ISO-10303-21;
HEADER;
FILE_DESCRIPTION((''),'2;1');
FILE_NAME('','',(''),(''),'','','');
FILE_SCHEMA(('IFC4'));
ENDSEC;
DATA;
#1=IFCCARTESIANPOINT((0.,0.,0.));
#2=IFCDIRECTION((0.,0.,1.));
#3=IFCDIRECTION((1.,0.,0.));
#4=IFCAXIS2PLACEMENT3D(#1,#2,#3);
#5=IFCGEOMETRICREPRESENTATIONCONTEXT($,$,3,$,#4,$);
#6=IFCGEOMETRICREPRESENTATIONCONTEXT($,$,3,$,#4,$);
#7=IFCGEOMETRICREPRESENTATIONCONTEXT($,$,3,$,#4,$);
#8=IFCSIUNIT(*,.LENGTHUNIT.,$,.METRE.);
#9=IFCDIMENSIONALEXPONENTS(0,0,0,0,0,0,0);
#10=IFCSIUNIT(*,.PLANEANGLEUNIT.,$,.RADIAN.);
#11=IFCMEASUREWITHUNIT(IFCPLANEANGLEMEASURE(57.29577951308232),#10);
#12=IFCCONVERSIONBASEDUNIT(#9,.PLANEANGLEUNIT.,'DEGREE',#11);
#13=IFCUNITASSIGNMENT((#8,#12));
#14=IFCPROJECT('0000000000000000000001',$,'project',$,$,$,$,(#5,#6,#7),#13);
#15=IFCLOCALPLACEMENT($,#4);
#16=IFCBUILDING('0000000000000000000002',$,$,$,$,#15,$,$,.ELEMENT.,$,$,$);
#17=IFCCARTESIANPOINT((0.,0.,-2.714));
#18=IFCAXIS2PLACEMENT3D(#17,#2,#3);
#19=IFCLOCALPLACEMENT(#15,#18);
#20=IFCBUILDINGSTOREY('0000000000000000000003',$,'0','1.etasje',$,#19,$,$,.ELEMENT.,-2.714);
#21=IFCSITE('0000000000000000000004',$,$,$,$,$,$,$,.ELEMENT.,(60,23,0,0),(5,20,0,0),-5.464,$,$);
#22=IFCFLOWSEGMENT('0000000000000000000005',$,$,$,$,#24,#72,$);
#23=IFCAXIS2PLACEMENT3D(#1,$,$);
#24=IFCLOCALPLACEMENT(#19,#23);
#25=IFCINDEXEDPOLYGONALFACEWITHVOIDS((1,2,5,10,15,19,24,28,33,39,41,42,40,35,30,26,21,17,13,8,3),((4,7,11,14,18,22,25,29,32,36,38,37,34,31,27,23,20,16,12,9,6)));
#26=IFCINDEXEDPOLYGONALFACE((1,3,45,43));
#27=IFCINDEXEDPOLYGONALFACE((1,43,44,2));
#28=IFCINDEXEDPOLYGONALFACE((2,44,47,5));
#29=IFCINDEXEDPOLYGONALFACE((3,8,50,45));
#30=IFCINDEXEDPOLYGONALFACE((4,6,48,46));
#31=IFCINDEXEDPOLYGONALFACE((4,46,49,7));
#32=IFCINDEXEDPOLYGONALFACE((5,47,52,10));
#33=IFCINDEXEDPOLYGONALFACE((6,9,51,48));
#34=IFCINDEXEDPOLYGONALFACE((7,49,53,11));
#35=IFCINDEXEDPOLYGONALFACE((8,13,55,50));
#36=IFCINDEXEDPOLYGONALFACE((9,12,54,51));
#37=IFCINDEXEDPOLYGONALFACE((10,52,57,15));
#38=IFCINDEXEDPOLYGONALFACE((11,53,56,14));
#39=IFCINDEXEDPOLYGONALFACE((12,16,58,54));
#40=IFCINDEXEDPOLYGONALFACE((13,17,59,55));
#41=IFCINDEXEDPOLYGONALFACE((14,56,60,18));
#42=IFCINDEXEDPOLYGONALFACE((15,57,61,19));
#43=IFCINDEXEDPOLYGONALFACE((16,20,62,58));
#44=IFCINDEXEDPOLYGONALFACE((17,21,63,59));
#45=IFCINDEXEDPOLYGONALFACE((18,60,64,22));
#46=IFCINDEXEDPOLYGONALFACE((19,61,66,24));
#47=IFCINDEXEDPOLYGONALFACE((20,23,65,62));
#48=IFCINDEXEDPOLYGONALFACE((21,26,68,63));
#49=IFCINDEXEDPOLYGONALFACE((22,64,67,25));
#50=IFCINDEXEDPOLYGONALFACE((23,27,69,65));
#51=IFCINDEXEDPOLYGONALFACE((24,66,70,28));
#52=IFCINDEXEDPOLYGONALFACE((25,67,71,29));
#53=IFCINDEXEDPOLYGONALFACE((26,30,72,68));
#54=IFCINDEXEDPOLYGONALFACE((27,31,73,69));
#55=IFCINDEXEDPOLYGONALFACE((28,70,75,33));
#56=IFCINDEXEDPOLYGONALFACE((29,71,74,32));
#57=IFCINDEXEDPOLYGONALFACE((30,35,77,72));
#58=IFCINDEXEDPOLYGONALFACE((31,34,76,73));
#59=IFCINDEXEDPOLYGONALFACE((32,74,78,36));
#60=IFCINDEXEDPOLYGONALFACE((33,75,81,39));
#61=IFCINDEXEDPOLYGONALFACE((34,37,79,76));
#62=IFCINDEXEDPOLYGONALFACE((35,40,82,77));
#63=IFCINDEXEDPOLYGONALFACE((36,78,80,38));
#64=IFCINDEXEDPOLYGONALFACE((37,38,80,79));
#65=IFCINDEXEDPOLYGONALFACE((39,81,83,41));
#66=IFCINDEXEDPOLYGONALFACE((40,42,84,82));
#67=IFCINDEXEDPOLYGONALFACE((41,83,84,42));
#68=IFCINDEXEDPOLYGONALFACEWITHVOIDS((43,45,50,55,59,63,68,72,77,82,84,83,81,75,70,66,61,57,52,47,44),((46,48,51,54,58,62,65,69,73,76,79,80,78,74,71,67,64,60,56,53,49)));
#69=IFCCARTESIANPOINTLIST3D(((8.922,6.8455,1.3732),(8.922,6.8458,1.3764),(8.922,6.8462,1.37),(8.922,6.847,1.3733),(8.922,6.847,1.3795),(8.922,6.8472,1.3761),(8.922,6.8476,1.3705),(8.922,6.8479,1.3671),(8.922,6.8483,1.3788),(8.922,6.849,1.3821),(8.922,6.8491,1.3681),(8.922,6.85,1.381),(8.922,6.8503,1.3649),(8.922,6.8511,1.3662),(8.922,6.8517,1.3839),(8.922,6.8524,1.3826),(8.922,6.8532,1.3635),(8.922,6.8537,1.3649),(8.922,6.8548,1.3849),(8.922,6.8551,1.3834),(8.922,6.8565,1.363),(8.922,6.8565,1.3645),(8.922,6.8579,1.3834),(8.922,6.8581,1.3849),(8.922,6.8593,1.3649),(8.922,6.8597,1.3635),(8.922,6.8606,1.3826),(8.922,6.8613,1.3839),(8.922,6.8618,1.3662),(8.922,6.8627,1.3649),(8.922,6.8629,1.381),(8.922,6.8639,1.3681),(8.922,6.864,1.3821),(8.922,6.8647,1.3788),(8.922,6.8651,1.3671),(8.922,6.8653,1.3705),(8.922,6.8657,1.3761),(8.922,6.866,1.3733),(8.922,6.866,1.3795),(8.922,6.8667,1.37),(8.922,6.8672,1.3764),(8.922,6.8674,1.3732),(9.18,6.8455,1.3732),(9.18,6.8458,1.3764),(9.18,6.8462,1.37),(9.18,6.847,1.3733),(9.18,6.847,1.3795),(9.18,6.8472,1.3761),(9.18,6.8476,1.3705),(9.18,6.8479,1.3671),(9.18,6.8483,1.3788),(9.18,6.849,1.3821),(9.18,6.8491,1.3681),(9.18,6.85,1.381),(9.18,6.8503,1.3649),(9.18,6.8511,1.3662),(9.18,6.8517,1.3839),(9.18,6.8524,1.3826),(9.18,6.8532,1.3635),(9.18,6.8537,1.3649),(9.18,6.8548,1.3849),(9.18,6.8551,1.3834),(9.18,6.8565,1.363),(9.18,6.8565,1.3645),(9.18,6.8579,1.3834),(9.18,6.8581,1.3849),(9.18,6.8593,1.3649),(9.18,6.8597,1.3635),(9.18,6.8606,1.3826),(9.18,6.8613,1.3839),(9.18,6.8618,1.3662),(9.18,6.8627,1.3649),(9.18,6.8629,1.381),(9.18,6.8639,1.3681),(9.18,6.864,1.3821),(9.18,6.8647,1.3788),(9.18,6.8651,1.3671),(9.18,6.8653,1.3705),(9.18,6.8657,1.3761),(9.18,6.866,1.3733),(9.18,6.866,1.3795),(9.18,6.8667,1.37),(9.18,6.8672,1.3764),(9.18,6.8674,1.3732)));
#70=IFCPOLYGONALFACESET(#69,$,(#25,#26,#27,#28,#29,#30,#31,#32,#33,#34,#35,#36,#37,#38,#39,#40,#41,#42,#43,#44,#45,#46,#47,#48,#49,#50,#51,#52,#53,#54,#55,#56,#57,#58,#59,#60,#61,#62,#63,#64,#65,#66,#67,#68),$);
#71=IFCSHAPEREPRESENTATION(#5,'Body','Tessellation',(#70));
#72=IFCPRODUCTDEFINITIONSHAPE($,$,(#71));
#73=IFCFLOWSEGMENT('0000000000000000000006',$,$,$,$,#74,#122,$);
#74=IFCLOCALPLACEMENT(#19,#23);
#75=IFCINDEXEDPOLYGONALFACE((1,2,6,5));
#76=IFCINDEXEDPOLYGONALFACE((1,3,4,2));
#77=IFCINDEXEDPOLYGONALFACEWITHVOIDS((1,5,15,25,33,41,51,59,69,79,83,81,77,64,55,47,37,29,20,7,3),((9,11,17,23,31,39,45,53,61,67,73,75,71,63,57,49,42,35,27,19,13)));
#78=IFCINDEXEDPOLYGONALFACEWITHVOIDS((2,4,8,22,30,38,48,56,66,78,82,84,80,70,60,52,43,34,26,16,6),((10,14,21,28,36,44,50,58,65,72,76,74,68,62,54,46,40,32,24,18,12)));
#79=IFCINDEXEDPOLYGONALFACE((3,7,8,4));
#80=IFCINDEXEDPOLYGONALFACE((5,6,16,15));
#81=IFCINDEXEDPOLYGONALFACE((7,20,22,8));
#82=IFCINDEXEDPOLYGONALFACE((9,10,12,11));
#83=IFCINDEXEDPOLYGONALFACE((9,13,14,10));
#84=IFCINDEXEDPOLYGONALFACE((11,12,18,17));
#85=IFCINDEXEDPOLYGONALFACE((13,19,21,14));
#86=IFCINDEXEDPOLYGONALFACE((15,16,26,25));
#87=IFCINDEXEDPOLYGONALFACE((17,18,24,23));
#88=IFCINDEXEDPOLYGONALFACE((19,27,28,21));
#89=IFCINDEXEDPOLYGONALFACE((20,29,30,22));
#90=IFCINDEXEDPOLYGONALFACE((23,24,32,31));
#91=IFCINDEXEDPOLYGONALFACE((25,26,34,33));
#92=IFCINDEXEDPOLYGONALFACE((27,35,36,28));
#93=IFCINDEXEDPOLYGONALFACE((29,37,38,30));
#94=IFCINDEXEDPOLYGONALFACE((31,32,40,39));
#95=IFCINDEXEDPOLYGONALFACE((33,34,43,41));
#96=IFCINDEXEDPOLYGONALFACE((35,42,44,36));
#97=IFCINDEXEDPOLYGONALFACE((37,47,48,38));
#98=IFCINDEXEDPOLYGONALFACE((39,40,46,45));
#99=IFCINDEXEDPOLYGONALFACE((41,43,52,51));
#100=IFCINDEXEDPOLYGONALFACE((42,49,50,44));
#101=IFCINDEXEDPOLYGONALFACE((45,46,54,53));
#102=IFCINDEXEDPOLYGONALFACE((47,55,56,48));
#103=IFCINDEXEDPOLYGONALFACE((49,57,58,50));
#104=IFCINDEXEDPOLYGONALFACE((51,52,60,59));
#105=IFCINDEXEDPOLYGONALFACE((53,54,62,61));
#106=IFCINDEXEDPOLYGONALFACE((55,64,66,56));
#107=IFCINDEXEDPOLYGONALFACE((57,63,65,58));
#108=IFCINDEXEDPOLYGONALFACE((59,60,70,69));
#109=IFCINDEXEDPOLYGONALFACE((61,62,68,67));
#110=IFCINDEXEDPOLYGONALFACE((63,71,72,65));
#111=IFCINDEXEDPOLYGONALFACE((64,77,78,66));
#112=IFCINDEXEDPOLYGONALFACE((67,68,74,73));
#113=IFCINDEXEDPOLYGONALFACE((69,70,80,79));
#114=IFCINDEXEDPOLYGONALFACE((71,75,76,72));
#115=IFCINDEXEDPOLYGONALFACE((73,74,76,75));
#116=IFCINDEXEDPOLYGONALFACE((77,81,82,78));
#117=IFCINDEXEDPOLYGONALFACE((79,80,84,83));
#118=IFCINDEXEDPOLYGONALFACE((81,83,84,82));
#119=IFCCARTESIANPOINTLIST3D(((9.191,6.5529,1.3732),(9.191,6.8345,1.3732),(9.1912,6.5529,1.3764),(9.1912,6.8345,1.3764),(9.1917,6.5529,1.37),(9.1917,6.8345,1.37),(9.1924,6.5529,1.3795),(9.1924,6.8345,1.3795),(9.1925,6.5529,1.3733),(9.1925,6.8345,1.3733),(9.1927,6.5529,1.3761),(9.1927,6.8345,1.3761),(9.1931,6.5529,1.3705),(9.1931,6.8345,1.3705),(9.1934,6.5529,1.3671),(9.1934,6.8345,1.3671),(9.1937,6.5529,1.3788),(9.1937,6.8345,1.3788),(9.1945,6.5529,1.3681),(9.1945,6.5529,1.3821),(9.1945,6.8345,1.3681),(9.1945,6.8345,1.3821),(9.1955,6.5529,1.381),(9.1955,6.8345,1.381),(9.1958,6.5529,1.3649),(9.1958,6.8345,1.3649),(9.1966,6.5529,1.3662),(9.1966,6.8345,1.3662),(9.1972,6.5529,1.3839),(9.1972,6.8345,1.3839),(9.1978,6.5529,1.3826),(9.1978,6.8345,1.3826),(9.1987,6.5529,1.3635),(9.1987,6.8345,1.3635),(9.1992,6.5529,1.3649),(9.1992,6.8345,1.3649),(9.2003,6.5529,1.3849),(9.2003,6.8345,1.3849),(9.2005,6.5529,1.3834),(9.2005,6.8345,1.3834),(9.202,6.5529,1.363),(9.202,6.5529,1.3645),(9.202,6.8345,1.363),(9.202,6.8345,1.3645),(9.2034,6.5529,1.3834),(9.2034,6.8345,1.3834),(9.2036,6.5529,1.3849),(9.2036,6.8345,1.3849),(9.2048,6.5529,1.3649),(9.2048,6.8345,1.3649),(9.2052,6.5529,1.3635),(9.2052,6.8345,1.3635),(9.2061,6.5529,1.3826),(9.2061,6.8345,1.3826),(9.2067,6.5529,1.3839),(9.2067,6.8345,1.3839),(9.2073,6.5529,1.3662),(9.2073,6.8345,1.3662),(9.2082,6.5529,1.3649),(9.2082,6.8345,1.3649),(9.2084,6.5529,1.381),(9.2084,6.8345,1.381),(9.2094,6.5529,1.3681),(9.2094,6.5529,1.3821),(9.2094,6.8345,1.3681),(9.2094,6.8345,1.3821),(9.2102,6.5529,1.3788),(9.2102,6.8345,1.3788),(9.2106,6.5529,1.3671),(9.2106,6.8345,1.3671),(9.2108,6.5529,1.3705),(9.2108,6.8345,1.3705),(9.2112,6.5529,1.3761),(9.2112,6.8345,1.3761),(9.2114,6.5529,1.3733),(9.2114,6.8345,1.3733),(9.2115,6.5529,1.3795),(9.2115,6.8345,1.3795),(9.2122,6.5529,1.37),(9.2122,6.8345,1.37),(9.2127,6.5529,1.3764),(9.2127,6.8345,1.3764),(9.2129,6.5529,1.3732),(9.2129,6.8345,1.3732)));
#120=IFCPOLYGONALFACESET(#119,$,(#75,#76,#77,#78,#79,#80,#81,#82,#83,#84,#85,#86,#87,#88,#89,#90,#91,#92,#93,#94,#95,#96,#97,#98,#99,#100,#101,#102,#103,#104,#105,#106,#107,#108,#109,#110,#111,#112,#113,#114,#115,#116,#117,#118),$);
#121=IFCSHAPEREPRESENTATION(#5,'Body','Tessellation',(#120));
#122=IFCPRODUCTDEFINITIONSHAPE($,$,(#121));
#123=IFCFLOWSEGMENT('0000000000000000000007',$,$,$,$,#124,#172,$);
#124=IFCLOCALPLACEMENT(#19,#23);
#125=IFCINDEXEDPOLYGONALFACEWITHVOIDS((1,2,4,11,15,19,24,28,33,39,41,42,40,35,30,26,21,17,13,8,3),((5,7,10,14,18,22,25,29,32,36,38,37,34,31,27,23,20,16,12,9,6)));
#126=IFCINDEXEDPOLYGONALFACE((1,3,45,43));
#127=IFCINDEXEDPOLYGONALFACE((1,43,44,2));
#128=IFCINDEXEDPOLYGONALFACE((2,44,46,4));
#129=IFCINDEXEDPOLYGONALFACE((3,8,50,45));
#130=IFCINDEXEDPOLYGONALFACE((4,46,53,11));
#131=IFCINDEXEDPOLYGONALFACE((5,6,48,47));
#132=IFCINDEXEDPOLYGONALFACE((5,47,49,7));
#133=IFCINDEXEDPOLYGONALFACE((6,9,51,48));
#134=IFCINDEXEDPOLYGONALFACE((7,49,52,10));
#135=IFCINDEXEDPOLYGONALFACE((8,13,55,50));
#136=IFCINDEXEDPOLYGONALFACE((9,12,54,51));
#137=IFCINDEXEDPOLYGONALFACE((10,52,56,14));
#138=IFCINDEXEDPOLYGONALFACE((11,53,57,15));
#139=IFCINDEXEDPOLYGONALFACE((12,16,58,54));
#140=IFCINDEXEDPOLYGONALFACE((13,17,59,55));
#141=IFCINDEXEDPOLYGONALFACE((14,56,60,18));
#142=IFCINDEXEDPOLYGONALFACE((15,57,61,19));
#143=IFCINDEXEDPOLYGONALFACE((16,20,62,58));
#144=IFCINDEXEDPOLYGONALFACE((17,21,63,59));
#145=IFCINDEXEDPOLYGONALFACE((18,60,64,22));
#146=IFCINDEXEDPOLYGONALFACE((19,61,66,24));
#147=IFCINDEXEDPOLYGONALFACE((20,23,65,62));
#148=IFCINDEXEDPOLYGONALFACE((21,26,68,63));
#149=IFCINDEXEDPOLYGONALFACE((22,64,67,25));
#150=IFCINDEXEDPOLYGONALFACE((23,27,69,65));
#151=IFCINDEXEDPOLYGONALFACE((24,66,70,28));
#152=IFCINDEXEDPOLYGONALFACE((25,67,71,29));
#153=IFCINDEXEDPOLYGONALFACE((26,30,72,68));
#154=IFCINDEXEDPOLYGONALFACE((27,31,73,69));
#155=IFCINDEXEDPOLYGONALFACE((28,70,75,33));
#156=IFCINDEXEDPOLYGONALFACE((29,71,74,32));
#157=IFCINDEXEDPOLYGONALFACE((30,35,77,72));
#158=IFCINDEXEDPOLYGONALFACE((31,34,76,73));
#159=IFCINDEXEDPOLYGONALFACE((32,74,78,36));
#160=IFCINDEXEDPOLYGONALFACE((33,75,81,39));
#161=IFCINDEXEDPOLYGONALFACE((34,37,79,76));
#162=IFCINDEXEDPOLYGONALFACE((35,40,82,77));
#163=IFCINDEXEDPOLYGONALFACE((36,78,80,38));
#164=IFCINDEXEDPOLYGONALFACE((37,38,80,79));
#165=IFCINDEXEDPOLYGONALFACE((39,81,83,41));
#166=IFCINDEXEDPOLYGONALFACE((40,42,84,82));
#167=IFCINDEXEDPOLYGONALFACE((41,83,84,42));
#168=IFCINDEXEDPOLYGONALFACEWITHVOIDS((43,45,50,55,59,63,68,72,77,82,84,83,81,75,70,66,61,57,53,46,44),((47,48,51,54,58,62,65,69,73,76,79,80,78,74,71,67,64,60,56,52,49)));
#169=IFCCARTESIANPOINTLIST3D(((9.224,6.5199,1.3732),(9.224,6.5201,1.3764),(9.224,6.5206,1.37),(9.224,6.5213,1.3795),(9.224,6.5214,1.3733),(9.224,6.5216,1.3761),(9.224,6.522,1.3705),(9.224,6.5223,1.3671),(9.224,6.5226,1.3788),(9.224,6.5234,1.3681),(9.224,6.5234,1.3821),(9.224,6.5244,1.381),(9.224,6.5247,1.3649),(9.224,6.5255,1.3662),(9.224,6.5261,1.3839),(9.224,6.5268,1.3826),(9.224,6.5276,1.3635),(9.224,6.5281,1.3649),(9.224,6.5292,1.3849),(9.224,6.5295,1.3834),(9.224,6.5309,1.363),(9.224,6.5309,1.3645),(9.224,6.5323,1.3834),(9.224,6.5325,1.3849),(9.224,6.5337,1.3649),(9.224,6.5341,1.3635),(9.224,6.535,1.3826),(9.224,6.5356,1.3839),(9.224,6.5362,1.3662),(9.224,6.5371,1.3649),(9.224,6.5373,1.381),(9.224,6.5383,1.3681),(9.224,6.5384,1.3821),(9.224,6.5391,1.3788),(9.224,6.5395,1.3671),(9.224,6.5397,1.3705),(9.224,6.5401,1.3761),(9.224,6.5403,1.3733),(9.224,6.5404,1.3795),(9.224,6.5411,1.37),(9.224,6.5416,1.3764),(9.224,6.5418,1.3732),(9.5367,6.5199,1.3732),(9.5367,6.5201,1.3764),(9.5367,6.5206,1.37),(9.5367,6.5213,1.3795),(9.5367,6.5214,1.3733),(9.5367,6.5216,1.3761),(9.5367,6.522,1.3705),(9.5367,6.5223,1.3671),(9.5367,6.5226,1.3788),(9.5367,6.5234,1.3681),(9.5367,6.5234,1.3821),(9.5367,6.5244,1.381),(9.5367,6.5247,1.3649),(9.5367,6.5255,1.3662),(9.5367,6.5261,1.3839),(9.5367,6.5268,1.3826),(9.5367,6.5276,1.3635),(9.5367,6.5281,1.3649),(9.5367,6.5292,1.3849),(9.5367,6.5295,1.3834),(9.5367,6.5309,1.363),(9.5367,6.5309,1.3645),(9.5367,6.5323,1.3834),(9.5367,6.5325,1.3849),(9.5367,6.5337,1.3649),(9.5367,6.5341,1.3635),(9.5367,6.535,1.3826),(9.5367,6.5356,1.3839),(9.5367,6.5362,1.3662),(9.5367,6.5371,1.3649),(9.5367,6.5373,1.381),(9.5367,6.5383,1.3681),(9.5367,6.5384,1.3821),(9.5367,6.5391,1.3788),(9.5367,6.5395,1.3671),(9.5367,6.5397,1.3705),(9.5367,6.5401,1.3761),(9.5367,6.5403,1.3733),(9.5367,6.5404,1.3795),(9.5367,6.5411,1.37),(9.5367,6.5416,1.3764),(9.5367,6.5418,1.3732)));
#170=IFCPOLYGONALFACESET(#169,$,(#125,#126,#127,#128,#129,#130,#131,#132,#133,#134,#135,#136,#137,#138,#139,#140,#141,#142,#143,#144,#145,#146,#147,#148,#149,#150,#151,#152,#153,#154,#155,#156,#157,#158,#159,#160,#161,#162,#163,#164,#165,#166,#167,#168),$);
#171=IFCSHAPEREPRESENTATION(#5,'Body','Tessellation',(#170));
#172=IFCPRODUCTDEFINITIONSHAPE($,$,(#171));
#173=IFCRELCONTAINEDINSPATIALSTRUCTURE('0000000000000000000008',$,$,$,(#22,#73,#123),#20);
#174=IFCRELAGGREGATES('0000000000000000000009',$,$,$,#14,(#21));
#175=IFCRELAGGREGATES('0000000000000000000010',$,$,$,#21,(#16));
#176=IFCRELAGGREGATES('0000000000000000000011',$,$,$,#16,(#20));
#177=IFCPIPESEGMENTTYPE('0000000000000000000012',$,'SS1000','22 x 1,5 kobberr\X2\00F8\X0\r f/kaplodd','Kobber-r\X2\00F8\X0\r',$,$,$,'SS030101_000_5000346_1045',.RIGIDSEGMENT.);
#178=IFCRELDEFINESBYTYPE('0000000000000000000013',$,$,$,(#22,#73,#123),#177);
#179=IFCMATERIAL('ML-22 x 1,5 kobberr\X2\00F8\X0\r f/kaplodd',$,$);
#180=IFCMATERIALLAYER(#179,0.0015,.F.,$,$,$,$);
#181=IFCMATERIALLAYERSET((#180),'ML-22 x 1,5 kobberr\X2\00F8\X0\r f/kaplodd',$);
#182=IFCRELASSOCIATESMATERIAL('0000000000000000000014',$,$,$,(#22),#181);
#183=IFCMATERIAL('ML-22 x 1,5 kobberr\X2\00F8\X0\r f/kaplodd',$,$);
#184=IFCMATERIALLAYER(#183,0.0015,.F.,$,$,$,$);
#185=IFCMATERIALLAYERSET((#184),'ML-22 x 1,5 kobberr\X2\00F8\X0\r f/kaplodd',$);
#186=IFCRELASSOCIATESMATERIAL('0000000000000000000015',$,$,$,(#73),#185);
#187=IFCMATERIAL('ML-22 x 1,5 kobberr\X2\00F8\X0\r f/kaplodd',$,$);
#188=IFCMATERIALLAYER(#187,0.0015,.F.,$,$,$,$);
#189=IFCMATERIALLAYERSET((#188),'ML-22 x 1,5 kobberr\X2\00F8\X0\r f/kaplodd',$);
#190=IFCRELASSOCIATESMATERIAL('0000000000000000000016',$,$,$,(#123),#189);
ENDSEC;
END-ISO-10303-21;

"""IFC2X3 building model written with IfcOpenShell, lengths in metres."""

from ifc_helpers import new_model, entity, si_unit, converted_unit, frame, origin_with_axes, origin_2d_with_axis, place, context, project, spatial, hollow_circle, extrude, material, layer, layer_set, layer_usage, type_object, element, save


model = new_model("IFC2X3")

# Units and contexts
context_of_model_1 = context(None, 3, world=origin_with_axes())
context_of_model_2 = context(None, 3, world=origin_with_axes())
context_of_model_3 = context(None, 3, world=origin_with_axes())
ifc_project = project(units=[si_unit("LENGTHUNIT", "METRE"), converted_unit("PLANEANGLEUNIT", "DEGREE", entity("IfcPlaneAngleMeasure", 57.29577951308232), si_unit("PLANEANGLEUNIT", "RADIAN"), dimensions=[0, 0, 0, 0, 0, 0, 0])], contexts=[context_of_model_1, context_of_model_2, context_of_model_3])

# Site, building, storey
site = spatial("IfcSite", under=ifc_project, CompositionType="ELEMENT", RefLatitude=(60, 23, 0, 0), RefLongitude=(5, 20, 0, 0), RefElevation=-5.464)
building_placement = place(None, origin_with_axes())
building = spatial("IfcBuilding", under=site, at=building_placement, CompositionType="ELEMENT")
storey_placement = place(building_placement, frame((0.0, 0.0, -2.714), z_axis=(0.0, 0.0, 1.0), x_axis=(1.0, 0.0, 0.0)))
storey = spatial("IfcBuildingStorey", under=building, at=storey_placement, Name="0", Description="1.etasje", CompositionType="ELEMENT", Elevation=-2.714)

# Flow segments
pipe_segment_type_1 = type_object("IfcPipeSegmentType", Name="SS1000", Description="22 x 1,5 kobberrør f/kaplodd", ApplicableOccurrence="Kobber-rør", ElementType="SS030101_000_5000346_1045", PredefinedType="RIGIDSEGMENT")
ifc_material_1 = material(Name="ML-22 x 1,5 kobberrør f/kaplodd")
ifc_layer_1 = layer(ifc_material_1, 0.0015, ventilated=False)
ifc_layer_set_1 = layer_set([ifc_layer_1], Name="ML-22 x 1,5 kobberrør f/kaplodd")
ifc_layer_usage_1 = layer_usage(ifc_layer_set_1, "AXIS2", "POSITIVE", 0.0)
flow_segment_1_placement = place(storey_placement, frame((8.922, 6.8565, 1.374), z_axis=(1.0, 0.0, 0.0), x_axis=(0.0, 0.0, -1.0)))
element("IfcFlowSegment", 1, at=flow_segment_1_placement, inside=storey, type_object=pipe_segment_type_1, material=ifc_layer_usage_1, context=context_of_model_1, shape_type="SweptSolid", body=[
    extrude(hollow_circle(Radius=0.011, WallThickness=0.0015, at=origin_2d_with_axis()), origin_with_axes(), (0.0, 0.0, 1.0), 0.2579),
])
ifc_material_2 = material(Name="ML-22 x 1,5 kobberrør f/kaplodd")
ifc_layer_2 = layer(ifc_material_2, 0.0015, ventilated=False)
ifc_layer_set_2 = layer_set([ifc_layer_2], Name="ML-22 x 1,5 kobberrør f/kaplodd")
ifc_layer_usage_2 = layer_usage(ifc_layer_set_2, "AXIS2", "POSITIVE", 0.0)
flow_segment_2_placement = place(storey_placement, frame((9.202, 6.8345, 1.374), z_axis=(0.0, -1.0, 0.0), x_axis=(0.0, 0.0, -1.0)))
element("IfcFlowSegment", 2, at=flow_segment_2_placement, inside=storey, type_object=pipe_segment_type_1, material=ifc_layer_usage_2, context=context_of_model_1, shape_type="SweptSolid", body=[
    extrude(hollow_circle(Radius=0.011, WallThickness=0.0015, at=origin_2d_with_axis()), origin_with_axes(), (0.0, 0.0, 1.0), 0.2816),
])
ifc_material_3 = material(Name="ML-22 x 1,5 kobberrør f/kaplodd")
ifc_layer_3 = layer(ifc_material_3, 0.0015, ventilated=False)
ifc_layer_set_3 = layer_set([ifc_layer_3], Name="ML-22 x 1,5 kobberrør f/kaplodd")
ifc_layer_usage_3 = layer_usage(ifc_layer_set_3, "AXIS2", "POSITIVE", 0.0)
flow_segment_3_placement = place(storey_placement, frame((9.224, 6.5309, 1.374), z_axis=(1.0, 0.0, 0.0), x_axis=(0.0, 0.0, -1.0)))
element("IfcFlowSegment", 3, at=flow_segment_3_placement, inside=storey, type_object=pipe_segment_type_1, material=ifc_layer_usage_3, context=context_of_model_1, shape_type="SweptSolid", body=[
    extrude(hollow_circle(Radius=0.011, WallThickness=0.0015, at=origin_2d_with_axis()), origin_with_axes(), (0.0, 0.0, 1.0), 0.3127),
])

save(model, "model.ifc")
